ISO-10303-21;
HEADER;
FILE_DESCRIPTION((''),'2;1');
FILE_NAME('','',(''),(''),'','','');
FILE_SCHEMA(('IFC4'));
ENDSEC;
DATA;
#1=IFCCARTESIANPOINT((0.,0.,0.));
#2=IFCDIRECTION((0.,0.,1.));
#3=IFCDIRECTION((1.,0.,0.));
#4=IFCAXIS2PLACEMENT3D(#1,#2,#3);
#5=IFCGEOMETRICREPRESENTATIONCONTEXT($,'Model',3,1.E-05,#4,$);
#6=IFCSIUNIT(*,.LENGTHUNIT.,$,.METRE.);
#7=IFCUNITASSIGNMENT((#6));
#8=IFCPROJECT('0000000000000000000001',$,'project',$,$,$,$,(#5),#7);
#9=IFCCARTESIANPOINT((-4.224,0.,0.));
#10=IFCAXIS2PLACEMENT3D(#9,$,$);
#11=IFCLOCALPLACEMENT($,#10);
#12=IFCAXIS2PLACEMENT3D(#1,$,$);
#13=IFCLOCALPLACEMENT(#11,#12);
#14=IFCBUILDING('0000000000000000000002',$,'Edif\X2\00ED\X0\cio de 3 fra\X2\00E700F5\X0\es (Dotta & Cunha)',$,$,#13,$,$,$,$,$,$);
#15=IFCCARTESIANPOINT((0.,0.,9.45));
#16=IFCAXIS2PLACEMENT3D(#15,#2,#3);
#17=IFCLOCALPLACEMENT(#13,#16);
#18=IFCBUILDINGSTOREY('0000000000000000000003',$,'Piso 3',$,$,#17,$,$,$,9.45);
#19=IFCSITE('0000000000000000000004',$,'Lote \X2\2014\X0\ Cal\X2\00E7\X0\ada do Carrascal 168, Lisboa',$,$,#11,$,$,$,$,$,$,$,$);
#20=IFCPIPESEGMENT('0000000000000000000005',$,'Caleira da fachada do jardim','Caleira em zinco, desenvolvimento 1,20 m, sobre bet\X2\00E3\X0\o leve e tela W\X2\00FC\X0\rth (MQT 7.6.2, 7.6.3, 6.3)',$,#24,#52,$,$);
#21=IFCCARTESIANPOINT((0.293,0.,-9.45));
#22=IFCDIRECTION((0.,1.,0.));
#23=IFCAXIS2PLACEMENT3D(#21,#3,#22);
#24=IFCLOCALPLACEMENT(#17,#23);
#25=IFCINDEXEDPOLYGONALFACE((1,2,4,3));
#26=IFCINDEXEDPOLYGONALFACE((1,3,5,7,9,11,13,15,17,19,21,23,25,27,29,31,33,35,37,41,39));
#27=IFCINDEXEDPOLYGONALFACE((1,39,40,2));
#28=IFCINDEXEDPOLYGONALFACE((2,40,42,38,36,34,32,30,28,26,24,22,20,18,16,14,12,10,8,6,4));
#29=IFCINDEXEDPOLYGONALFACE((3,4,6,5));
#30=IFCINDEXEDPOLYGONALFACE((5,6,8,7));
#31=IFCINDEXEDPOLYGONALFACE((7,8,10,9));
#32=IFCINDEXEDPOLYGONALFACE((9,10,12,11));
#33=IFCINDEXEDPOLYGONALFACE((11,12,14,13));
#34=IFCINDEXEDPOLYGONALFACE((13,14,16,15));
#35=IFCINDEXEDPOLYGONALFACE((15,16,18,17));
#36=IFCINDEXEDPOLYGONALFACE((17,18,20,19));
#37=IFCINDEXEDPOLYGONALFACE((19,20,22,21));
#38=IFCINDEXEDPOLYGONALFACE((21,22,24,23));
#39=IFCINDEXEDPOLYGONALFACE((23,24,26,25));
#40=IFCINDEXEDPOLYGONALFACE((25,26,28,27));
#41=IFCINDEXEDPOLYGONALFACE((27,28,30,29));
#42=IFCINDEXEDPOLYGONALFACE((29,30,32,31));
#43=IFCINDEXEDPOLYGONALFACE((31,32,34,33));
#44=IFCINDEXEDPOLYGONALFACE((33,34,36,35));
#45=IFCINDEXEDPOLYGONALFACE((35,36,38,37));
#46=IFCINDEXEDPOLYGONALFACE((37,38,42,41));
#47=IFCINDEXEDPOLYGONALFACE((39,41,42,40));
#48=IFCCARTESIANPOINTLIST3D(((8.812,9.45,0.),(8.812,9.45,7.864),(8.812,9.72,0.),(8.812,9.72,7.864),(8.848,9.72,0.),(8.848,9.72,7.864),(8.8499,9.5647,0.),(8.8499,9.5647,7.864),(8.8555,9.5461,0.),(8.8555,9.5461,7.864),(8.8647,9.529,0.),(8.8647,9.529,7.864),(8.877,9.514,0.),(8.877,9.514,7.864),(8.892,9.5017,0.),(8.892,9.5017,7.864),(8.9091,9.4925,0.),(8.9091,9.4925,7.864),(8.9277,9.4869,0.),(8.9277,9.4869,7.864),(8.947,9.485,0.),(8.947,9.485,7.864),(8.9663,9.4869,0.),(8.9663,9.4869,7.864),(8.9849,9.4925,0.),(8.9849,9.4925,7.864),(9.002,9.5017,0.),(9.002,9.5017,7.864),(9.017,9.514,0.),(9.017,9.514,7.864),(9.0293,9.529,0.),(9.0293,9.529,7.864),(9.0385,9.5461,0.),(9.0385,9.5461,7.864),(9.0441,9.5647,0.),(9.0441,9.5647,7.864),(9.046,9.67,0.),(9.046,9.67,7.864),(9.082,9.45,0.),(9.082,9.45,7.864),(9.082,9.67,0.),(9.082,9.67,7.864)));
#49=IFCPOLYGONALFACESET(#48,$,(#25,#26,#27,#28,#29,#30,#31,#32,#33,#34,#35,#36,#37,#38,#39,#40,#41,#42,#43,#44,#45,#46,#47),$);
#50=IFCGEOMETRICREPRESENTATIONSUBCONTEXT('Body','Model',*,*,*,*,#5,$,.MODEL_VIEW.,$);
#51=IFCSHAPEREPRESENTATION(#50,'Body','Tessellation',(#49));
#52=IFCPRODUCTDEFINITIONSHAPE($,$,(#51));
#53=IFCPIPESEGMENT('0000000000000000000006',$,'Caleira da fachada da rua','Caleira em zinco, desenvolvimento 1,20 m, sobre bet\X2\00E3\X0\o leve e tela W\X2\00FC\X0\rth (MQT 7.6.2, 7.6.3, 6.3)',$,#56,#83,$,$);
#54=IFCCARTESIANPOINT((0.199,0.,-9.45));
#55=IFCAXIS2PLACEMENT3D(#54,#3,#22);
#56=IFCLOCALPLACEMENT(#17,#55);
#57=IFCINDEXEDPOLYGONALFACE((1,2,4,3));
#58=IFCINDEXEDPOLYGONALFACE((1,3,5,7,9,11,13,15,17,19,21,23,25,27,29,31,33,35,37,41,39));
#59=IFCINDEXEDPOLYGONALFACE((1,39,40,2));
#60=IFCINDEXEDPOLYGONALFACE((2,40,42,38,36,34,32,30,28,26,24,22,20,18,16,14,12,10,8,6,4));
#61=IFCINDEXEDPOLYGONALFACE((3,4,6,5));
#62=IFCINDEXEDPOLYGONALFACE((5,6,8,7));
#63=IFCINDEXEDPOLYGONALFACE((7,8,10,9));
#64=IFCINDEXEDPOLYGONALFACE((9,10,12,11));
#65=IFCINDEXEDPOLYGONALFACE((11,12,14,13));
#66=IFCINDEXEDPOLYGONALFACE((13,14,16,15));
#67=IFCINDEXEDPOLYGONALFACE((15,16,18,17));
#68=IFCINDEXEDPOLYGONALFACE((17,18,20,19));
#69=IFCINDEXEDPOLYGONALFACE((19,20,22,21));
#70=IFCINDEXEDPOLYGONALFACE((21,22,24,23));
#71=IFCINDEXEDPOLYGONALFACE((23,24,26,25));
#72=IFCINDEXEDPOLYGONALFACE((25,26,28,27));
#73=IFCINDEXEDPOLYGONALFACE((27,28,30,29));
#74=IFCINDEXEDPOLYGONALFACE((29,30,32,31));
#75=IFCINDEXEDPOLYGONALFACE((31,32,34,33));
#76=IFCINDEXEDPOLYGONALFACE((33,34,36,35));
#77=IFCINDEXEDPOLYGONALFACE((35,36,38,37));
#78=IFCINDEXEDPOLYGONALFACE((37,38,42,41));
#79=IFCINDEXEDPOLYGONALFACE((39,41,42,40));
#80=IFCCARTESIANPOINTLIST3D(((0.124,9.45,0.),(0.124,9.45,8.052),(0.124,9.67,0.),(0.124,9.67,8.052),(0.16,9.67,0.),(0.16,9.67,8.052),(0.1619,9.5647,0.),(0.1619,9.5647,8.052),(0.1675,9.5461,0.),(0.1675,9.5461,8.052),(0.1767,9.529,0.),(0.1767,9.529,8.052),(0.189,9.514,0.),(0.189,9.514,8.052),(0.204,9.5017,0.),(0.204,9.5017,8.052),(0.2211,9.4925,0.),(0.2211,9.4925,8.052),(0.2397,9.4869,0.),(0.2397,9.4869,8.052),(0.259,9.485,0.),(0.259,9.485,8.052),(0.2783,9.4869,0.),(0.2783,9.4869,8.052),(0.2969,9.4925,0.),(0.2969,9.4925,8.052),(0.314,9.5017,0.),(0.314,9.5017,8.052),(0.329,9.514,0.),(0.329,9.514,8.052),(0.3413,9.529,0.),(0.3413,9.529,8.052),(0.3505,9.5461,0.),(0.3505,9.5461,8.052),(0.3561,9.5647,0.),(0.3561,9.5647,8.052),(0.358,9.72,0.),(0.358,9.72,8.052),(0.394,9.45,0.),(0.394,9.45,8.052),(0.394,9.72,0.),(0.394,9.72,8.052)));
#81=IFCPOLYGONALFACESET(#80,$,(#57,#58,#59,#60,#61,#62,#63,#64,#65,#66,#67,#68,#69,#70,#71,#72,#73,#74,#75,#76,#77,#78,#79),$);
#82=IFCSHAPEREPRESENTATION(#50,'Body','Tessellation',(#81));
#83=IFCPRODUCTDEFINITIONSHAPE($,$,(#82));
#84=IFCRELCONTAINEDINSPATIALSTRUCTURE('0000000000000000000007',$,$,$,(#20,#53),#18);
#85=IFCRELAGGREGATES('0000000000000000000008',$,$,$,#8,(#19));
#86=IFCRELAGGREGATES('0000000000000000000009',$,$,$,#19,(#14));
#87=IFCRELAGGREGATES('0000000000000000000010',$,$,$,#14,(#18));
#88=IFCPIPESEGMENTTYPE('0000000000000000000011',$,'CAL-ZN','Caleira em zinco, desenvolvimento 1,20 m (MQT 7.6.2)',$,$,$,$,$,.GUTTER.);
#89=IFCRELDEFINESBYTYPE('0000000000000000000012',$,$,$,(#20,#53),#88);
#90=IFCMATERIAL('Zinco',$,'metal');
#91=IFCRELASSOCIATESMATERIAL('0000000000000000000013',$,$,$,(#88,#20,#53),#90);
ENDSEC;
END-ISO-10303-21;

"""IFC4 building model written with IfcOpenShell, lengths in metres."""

from ifc_helpers import new_model, si_unit, frame, origin, origin_with_axes, place, context, subcontext, project, spatial, line, indexed_curve, outline, extrude, material, type_object, element, save


model = new_model("IFC4")

# Units and contexts
model_context = context("Model", 3, precision=1e-05, world=origin_with_axes())
body_context = subcontext(model_context, "Body", "Model", "MODEL_VIEW")
ifc_project = project(units=[si_unit("LENGTHUNIT", "METRE")], contexts=[model_context])

# Site, building, storey
site_placement = place(None, frame((-4.224, 0.0, 0.0)))
site = spatial("IfcSite", under=ifc_project, at=site_placement, Name="Lote — Calçada do Carrascal 168, Lisboa")
building_placement = place(site_placement, origin())
building = spatial("IfcBuilding", under=site, at=building_placement, Name="Edifício de 3 frações (Dotta & Cunha)")
storey_placement = place(building_placement, frame((0.0, 0.0, 9.45), z_axis=(0.0, 0.0, 1.0), x_axis=(1.0, 0.0, 0.0)))
storey = spatial("IfcBuildingStorey", under=building, at=storey_placement, Name="Piso 3", Elevation=9.45)

# Pipe segments
ifc_material_1 = material(Name="Zinco", Category="metal")
pipe_segment_type = type_object("IfcPipeSegmentType", Name="CAL-ZN", Description="Caleira em zinco, desenvolvimento 1,20 m (MQT 7.6.2)", PredefinedType="GUTTER", material=ifc_material_1)
pipe_segment_1_placement = place(storey_placement, frame((0.293, 0.0, -9.45), z_axis=(1.0, 0.0, 0.0), x_axis=(0.0, 1.0, 0.0)))
element("IfcPipeSegment", 1, at=pipe_segment_1_placement, inside=storey, type_object=pipe_segment_type, material=ifc_material_1, Name="Caleira da fachada do jardim", Description="Caleira em zinco, desenvolvimento 1,20 m, sobre betão leve e tela Würth (MQT 7.6.2, 7.6.3, 6.3)", context=body_context, shape_type="SweptSolid", body=[
    extrude(outline(indexed_curve([(8.812, 9.45), (8.812, 9.72), (8.848, 9.72), (8.8499, 9.5647), (8.8555, 9.5461), (8.8647, 9.529), (8.877, 9.514), (8.892, 9.5017), (8.9091, 9.4925), (8.9277, 9.4869), (8.947, 9.485), (8.9663, 9.4869), (8.9849, 9.4925), (9.002, 9.5017), (9.017, 9.514), (9.0293, 9.529), (9.0385, 9.5461), (9.0441, 9.5647), (9.046, 9.67), (9.082, 9.67), (9.082, 9.45)], segments=[line(1, 2, 3, 4, 5, 6, 7, 8, 9, 10, 11, 12, 13, 14, 15, 16, 17, 18, 19, 20, 21, 1)])), origin_with_axes(), (0.0, 0.0, 1.0), 7.864),
])
pipe_segment_2_placement = place(storey_placement, frame((0.199, 0.0, -9.45), z_axis=(1.0, 0.0, 0.0), x_axis=(0.0, 1.0, 0.0)))
element("IfcPipeSegment", 2, at=pipe_segment_2_placement, inside=storey, type_object=pipe_segment_type, material=ifc_material_1, Name="Caleira da fachada da rua", Description="Caleira em zinco, desenvolvimento 1,20 m, sobre betão leve e tela Würth (MQT 7.6.2, 7.6.3, 6.3)", context=body_context, shape_type="SweptSolid", body=[
    extrude(outline(indexed_curve([(0.394, 9.45), (0.124, 9.45), (0.124, 9.67), (0.16, 9.67), (0.1619, 9.5647), (0.1675, 9.5461), (0.1767, 9.529), (0.189, 9.514), (0.204, 9.5017), (0.2211, 9.4925), (0.2397, 9.4869), (0.259, 9.485), (0.2783, 9.4869), (0.2969, 9.4925), (0.314, 9.5017), (0.329, 9.514), (0.3413, 9.529), (0.3505, 9.5461), (0.3561, 9.5647), (0.358, 9.72), (0.394, 9.72)], segments=[line(1, 2, 3, 4, 5, 6, 7, 8, 9, 10, 11, 12, 13, 14, 15, 16, 17, 18, 19, 20, 21, 1)])), origin_with_axes(), (0.0, 0.0, 1.0), 8.052),
])

save(model, "model.ifc")
